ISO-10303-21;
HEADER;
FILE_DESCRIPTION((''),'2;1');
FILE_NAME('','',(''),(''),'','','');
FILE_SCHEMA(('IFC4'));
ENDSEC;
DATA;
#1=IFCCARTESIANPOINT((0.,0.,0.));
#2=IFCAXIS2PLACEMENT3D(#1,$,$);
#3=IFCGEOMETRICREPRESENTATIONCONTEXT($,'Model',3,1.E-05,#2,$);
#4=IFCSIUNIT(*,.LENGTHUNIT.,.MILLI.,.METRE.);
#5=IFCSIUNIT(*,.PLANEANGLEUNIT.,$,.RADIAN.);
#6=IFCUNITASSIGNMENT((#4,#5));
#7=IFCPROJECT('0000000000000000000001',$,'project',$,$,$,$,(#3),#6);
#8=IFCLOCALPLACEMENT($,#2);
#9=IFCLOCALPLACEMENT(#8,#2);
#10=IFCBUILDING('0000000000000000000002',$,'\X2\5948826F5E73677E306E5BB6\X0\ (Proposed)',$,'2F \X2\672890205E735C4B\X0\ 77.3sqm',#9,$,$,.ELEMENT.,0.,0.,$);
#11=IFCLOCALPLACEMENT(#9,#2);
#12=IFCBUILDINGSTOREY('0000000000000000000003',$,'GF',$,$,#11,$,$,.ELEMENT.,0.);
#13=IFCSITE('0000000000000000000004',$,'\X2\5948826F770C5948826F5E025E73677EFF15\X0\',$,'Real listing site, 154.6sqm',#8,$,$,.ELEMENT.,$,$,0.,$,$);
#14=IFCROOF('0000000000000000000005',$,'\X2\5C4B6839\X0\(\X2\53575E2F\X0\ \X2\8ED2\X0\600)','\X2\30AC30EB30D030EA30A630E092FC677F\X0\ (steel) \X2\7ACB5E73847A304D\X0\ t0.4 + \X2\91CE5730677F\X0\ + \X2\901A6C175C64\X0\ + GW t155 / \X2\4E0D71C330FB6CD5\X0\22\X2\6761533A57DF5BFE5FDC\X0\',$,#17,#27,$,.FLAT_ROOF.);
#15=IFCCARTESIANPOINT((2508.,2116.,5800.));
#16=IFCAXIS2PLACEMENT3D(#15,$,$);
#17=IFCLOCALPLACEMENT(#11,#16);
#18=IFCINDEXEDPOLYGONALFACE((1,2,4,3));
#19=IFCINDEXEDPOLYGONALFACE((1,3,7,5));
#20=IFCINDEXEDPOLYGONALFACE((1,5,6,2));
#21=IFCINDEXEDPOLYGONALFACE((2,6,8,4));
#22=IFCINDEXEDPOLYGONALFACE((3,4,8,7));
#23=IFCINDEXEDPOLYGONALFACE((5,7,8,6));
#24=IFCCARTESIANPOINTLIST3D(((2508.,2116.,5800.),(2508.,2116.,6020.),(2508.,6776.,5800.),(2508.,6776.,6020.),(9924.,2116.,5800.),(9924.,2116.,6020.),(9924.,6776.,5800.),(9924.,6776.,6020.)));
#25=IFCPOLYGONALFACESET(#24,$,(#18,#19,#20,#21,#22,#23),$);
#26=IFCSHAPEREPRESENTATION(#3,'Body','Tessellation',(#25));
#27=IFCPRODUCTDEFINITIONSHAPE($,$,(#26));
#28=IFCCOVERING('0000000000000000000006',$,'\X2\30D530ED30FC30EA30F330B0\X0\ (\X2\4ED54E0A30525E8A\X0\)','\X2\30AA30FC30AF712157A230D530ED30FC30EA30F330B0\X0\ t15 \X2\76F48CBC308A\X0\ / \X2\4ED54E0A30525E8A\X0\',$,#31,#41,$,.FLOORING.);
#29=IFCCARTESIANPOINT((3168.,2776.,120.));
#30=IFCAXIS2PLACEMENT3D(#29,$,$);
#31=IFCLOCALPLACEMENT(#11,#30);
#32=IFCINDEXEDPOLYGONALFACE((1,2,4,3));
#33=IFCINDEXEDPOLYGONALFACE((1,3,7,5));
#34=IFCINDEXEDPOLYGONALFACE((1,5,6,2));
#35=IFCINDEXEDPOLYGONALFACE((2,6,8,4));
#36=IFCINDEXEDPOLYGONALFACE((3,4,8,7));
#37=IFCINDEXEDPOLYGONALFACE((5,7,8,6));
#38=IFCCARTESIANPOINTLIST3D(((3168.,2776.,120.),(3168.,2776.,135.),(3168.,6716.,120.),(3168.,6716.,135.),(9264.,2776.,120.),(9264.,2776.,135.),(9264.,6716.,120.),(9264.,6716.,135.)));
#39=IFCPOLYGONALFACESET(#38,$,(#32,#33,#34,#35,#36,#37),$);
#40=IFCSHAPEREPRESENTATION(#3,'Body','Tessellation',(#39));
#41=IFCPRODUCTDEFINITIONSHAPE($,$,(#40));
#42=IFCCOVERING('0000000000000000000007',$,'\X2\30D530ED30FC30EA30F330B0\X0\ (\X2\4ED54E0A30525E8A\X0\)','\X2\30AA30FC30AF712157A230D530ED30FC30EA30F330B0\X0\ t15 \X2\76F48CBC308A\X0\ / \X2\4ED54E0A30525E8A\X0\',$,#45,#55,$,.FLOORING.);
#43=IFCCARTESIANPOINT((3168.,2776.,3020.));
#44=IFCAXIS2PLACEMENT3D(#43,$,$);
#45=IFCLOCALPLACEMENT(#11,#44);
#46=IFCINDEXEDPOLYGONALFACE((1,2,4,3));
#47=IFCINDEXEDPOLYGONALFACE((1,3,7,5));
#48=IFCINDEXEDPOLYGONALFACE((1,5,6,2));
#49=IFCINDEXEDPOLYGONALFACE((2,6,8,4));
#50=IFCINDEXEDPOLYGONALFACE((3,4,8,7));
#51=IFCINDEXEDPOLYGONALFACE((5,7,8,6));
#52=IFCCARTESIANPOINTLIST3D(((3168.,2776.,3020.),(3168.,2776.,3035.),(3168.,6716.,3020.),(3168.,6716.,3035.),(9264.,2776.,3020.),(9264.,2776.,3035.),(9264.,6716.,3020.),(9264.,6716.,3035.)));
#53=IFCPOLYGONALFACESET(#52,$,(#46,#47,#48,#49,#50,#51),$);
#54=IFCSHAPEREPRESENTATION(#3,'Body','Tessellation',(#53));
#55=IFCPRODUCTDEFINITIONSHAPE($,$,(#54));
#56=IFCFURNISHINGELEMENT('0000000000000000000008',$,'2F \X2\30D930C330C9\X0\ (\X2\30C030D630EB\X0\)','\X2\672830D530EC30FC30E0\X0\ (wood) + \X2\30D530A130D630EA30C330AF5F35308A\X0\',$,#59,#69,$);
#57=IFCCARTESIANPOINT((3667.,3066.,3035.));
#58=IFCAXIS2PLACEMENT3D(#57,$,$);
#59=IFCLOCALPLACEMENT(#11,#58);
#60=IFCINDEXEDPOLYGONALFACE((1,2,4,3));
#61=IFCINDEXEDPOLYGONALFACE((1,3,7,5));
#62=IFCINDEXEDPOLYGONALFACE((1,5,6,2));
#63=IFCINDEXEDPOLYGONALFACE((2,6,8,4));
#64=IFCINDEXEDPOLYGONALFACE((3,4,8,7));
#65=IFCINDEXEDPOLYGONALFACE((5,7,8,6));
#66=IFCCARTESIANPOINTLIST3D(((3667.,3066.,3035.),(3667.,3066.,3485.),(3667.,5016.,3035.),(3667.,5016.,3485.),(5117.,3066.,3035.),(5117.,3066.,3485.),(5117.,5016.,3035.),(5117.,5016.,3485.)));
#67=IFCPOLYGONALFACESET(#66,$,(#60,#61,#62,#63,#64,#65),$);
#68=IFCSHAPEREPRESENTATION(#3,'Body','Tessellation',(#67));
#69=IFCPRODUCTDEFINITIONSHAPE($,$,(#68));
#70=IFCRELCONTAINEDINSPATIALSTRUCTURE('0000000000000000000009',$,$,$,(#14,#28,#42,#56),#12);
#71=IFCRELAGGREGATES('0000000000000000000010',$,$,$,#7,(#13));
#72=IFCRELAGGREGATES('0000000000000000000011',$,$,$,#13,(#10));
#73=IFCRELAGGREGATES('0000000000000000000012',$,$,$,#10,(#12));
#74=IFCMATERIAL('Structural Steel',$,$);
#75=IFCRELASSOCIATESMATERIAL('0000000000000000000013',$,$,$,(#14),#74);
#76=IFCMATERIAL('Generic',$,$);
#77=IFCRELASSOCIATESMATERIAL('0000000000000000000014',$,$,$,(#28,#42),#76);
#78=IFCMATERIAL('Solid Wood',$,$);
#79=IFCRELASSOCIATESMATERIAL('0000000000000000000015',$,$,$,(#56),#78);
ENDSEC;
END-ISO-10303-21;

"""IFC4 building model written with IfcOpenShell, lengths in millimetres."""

from ifc_helpers import new_model, si_unit, frame, frame_2d, origin, place, context, project, spatial, rectangle, extrude, material, element, save


model = new_model("IFC4")

# Units and contexts
model_context = context("Model", 3, precision=1e-05, world=origin())
ifc_project = project(units=[si_unit("LENGTHUNIT", "METRE", prefix="MILLI"), si_unit("PLANEANGLEUNIT", "RADIAN")], contexts=[model_context])

# Site, building, storey
site_placement = place(None, origin())
site = spatial("IfcSite", under=ifc_project, at=site_placement, Name="奈良県奈良市平松５", ObjectType="Real listing site, 154.6sqm", CompositionType="ELEMENT", RefElevation=0.0)
building_placement = place(site_placement, origin())
building = spatial("IfcBuilding", under=site, at=building_placement, Name="奈良平松の家 (Proposed)", ObjectType="2F 木造平屋 77.3sqm", CompositionType="ELEMENT", ElevationOfRefHeight=0.0, ElevationOfTerrain=0.0)
storey_placement = place(building_placement, origin())
storey = spatial("IfcBuildingStorey", under=building, at=storey_placement, Name="GF", CompositionType="ELEMENT", Elevation=0.0)

# Shared definitions
ifc_material_1 = material(Name="Solid Wood")

# Roof
ifc_material_2 = material(Name="Structural Steel")
for number, where, name in (
    (1, (2508.0, 2116.0, 5800.0), "屋根(南帯 軒600)"),
):
    element("IfcRoof", number, at=place(storey_placement, frame(where)), inside=storey, material=ifc_material_2, Name=name, Description="ガルバリウム鋼板 (steel) 立平葺き t0.4 + 野地板 + 通気層 + GW t155 / 不燃・法22条区域対応", PredefinedType="FLAT_ROOF", context=model_context, shape_type="SweptSolid", body=[
        extrude(rectangle(XDim=7416.0, YDim=4660.0, at=frame_2d((3708.0, 2330.0))), frame((2508.0, 2116.0, 5800.0)), (0.0, 0.0, 1.0), 220.0),
    ])

# Coverings
ifc_material_3 = material(Name="Generic")
covering_1_placement = place(storey_placement, frame((3168.0, 2776.0, 120.0)))
element("IfcCovering", 2, at=covering_1_placement, inside=storey, material=ifc_material_3, Name="フローリング (仕上げ床)", Description="オーク無垢フローリング t15 直貼り / 仕上げ床", PredefinedType="FLOORING", context=model_context, shape_type="SweptSolid", body=[
    extrude(rectangle(XDim=6096.0, YDim=3940.0, at=frame_2d((3048.0, 1970.0))), frame((3168.0, 2776.0, 120.0)), (0.0, 0.0, 1.0), 15.0),
])
covering_2_placement = place(storey_placement, frame((3168.0, 2776.0, 3020.0)))
element("IfcCovering", 3, at=covering_2_placement, inside=storey, material=ifc_material_3, Name="フローリング (仕上げ床)", Description="オーク無垢フローリング t15 直貼り / 仕上げ床", PredefinedType="FLOORING", context=model_context, shape_type="SweptSolid", body=[
    extrude(rectangle(XDim=6096.0, YDim=3940.0, at=frame_2d((3048.0, 1970.0))), frame((3168.0, 2776.0, 3020.0)), (0.0, 0.0, 1.0), 15.0),
])

# Furnishing element
furnishing_placement = place(storey_placement, frame((3667.0, 3066.0, 3035.0)))
element("IfcFurnishingElement", 4, at=furnishing_placement, inside=storey, material=ifc_material_1, Name="2F ベッド (ダブル)", Description="木フレーム (wood) + ファブリック張り", context=model_context, shape_type="SweptSolid", body=[
    extrude(rectangle(XDim=1450.0, YDim=1950.0, at=frame_2d((725.0, 975.0))), frame((3667.0, 3066.0, 3035.0)), (0.0, 0.0, 1.0), 450.0),
])

save(model, "model.ifc")
